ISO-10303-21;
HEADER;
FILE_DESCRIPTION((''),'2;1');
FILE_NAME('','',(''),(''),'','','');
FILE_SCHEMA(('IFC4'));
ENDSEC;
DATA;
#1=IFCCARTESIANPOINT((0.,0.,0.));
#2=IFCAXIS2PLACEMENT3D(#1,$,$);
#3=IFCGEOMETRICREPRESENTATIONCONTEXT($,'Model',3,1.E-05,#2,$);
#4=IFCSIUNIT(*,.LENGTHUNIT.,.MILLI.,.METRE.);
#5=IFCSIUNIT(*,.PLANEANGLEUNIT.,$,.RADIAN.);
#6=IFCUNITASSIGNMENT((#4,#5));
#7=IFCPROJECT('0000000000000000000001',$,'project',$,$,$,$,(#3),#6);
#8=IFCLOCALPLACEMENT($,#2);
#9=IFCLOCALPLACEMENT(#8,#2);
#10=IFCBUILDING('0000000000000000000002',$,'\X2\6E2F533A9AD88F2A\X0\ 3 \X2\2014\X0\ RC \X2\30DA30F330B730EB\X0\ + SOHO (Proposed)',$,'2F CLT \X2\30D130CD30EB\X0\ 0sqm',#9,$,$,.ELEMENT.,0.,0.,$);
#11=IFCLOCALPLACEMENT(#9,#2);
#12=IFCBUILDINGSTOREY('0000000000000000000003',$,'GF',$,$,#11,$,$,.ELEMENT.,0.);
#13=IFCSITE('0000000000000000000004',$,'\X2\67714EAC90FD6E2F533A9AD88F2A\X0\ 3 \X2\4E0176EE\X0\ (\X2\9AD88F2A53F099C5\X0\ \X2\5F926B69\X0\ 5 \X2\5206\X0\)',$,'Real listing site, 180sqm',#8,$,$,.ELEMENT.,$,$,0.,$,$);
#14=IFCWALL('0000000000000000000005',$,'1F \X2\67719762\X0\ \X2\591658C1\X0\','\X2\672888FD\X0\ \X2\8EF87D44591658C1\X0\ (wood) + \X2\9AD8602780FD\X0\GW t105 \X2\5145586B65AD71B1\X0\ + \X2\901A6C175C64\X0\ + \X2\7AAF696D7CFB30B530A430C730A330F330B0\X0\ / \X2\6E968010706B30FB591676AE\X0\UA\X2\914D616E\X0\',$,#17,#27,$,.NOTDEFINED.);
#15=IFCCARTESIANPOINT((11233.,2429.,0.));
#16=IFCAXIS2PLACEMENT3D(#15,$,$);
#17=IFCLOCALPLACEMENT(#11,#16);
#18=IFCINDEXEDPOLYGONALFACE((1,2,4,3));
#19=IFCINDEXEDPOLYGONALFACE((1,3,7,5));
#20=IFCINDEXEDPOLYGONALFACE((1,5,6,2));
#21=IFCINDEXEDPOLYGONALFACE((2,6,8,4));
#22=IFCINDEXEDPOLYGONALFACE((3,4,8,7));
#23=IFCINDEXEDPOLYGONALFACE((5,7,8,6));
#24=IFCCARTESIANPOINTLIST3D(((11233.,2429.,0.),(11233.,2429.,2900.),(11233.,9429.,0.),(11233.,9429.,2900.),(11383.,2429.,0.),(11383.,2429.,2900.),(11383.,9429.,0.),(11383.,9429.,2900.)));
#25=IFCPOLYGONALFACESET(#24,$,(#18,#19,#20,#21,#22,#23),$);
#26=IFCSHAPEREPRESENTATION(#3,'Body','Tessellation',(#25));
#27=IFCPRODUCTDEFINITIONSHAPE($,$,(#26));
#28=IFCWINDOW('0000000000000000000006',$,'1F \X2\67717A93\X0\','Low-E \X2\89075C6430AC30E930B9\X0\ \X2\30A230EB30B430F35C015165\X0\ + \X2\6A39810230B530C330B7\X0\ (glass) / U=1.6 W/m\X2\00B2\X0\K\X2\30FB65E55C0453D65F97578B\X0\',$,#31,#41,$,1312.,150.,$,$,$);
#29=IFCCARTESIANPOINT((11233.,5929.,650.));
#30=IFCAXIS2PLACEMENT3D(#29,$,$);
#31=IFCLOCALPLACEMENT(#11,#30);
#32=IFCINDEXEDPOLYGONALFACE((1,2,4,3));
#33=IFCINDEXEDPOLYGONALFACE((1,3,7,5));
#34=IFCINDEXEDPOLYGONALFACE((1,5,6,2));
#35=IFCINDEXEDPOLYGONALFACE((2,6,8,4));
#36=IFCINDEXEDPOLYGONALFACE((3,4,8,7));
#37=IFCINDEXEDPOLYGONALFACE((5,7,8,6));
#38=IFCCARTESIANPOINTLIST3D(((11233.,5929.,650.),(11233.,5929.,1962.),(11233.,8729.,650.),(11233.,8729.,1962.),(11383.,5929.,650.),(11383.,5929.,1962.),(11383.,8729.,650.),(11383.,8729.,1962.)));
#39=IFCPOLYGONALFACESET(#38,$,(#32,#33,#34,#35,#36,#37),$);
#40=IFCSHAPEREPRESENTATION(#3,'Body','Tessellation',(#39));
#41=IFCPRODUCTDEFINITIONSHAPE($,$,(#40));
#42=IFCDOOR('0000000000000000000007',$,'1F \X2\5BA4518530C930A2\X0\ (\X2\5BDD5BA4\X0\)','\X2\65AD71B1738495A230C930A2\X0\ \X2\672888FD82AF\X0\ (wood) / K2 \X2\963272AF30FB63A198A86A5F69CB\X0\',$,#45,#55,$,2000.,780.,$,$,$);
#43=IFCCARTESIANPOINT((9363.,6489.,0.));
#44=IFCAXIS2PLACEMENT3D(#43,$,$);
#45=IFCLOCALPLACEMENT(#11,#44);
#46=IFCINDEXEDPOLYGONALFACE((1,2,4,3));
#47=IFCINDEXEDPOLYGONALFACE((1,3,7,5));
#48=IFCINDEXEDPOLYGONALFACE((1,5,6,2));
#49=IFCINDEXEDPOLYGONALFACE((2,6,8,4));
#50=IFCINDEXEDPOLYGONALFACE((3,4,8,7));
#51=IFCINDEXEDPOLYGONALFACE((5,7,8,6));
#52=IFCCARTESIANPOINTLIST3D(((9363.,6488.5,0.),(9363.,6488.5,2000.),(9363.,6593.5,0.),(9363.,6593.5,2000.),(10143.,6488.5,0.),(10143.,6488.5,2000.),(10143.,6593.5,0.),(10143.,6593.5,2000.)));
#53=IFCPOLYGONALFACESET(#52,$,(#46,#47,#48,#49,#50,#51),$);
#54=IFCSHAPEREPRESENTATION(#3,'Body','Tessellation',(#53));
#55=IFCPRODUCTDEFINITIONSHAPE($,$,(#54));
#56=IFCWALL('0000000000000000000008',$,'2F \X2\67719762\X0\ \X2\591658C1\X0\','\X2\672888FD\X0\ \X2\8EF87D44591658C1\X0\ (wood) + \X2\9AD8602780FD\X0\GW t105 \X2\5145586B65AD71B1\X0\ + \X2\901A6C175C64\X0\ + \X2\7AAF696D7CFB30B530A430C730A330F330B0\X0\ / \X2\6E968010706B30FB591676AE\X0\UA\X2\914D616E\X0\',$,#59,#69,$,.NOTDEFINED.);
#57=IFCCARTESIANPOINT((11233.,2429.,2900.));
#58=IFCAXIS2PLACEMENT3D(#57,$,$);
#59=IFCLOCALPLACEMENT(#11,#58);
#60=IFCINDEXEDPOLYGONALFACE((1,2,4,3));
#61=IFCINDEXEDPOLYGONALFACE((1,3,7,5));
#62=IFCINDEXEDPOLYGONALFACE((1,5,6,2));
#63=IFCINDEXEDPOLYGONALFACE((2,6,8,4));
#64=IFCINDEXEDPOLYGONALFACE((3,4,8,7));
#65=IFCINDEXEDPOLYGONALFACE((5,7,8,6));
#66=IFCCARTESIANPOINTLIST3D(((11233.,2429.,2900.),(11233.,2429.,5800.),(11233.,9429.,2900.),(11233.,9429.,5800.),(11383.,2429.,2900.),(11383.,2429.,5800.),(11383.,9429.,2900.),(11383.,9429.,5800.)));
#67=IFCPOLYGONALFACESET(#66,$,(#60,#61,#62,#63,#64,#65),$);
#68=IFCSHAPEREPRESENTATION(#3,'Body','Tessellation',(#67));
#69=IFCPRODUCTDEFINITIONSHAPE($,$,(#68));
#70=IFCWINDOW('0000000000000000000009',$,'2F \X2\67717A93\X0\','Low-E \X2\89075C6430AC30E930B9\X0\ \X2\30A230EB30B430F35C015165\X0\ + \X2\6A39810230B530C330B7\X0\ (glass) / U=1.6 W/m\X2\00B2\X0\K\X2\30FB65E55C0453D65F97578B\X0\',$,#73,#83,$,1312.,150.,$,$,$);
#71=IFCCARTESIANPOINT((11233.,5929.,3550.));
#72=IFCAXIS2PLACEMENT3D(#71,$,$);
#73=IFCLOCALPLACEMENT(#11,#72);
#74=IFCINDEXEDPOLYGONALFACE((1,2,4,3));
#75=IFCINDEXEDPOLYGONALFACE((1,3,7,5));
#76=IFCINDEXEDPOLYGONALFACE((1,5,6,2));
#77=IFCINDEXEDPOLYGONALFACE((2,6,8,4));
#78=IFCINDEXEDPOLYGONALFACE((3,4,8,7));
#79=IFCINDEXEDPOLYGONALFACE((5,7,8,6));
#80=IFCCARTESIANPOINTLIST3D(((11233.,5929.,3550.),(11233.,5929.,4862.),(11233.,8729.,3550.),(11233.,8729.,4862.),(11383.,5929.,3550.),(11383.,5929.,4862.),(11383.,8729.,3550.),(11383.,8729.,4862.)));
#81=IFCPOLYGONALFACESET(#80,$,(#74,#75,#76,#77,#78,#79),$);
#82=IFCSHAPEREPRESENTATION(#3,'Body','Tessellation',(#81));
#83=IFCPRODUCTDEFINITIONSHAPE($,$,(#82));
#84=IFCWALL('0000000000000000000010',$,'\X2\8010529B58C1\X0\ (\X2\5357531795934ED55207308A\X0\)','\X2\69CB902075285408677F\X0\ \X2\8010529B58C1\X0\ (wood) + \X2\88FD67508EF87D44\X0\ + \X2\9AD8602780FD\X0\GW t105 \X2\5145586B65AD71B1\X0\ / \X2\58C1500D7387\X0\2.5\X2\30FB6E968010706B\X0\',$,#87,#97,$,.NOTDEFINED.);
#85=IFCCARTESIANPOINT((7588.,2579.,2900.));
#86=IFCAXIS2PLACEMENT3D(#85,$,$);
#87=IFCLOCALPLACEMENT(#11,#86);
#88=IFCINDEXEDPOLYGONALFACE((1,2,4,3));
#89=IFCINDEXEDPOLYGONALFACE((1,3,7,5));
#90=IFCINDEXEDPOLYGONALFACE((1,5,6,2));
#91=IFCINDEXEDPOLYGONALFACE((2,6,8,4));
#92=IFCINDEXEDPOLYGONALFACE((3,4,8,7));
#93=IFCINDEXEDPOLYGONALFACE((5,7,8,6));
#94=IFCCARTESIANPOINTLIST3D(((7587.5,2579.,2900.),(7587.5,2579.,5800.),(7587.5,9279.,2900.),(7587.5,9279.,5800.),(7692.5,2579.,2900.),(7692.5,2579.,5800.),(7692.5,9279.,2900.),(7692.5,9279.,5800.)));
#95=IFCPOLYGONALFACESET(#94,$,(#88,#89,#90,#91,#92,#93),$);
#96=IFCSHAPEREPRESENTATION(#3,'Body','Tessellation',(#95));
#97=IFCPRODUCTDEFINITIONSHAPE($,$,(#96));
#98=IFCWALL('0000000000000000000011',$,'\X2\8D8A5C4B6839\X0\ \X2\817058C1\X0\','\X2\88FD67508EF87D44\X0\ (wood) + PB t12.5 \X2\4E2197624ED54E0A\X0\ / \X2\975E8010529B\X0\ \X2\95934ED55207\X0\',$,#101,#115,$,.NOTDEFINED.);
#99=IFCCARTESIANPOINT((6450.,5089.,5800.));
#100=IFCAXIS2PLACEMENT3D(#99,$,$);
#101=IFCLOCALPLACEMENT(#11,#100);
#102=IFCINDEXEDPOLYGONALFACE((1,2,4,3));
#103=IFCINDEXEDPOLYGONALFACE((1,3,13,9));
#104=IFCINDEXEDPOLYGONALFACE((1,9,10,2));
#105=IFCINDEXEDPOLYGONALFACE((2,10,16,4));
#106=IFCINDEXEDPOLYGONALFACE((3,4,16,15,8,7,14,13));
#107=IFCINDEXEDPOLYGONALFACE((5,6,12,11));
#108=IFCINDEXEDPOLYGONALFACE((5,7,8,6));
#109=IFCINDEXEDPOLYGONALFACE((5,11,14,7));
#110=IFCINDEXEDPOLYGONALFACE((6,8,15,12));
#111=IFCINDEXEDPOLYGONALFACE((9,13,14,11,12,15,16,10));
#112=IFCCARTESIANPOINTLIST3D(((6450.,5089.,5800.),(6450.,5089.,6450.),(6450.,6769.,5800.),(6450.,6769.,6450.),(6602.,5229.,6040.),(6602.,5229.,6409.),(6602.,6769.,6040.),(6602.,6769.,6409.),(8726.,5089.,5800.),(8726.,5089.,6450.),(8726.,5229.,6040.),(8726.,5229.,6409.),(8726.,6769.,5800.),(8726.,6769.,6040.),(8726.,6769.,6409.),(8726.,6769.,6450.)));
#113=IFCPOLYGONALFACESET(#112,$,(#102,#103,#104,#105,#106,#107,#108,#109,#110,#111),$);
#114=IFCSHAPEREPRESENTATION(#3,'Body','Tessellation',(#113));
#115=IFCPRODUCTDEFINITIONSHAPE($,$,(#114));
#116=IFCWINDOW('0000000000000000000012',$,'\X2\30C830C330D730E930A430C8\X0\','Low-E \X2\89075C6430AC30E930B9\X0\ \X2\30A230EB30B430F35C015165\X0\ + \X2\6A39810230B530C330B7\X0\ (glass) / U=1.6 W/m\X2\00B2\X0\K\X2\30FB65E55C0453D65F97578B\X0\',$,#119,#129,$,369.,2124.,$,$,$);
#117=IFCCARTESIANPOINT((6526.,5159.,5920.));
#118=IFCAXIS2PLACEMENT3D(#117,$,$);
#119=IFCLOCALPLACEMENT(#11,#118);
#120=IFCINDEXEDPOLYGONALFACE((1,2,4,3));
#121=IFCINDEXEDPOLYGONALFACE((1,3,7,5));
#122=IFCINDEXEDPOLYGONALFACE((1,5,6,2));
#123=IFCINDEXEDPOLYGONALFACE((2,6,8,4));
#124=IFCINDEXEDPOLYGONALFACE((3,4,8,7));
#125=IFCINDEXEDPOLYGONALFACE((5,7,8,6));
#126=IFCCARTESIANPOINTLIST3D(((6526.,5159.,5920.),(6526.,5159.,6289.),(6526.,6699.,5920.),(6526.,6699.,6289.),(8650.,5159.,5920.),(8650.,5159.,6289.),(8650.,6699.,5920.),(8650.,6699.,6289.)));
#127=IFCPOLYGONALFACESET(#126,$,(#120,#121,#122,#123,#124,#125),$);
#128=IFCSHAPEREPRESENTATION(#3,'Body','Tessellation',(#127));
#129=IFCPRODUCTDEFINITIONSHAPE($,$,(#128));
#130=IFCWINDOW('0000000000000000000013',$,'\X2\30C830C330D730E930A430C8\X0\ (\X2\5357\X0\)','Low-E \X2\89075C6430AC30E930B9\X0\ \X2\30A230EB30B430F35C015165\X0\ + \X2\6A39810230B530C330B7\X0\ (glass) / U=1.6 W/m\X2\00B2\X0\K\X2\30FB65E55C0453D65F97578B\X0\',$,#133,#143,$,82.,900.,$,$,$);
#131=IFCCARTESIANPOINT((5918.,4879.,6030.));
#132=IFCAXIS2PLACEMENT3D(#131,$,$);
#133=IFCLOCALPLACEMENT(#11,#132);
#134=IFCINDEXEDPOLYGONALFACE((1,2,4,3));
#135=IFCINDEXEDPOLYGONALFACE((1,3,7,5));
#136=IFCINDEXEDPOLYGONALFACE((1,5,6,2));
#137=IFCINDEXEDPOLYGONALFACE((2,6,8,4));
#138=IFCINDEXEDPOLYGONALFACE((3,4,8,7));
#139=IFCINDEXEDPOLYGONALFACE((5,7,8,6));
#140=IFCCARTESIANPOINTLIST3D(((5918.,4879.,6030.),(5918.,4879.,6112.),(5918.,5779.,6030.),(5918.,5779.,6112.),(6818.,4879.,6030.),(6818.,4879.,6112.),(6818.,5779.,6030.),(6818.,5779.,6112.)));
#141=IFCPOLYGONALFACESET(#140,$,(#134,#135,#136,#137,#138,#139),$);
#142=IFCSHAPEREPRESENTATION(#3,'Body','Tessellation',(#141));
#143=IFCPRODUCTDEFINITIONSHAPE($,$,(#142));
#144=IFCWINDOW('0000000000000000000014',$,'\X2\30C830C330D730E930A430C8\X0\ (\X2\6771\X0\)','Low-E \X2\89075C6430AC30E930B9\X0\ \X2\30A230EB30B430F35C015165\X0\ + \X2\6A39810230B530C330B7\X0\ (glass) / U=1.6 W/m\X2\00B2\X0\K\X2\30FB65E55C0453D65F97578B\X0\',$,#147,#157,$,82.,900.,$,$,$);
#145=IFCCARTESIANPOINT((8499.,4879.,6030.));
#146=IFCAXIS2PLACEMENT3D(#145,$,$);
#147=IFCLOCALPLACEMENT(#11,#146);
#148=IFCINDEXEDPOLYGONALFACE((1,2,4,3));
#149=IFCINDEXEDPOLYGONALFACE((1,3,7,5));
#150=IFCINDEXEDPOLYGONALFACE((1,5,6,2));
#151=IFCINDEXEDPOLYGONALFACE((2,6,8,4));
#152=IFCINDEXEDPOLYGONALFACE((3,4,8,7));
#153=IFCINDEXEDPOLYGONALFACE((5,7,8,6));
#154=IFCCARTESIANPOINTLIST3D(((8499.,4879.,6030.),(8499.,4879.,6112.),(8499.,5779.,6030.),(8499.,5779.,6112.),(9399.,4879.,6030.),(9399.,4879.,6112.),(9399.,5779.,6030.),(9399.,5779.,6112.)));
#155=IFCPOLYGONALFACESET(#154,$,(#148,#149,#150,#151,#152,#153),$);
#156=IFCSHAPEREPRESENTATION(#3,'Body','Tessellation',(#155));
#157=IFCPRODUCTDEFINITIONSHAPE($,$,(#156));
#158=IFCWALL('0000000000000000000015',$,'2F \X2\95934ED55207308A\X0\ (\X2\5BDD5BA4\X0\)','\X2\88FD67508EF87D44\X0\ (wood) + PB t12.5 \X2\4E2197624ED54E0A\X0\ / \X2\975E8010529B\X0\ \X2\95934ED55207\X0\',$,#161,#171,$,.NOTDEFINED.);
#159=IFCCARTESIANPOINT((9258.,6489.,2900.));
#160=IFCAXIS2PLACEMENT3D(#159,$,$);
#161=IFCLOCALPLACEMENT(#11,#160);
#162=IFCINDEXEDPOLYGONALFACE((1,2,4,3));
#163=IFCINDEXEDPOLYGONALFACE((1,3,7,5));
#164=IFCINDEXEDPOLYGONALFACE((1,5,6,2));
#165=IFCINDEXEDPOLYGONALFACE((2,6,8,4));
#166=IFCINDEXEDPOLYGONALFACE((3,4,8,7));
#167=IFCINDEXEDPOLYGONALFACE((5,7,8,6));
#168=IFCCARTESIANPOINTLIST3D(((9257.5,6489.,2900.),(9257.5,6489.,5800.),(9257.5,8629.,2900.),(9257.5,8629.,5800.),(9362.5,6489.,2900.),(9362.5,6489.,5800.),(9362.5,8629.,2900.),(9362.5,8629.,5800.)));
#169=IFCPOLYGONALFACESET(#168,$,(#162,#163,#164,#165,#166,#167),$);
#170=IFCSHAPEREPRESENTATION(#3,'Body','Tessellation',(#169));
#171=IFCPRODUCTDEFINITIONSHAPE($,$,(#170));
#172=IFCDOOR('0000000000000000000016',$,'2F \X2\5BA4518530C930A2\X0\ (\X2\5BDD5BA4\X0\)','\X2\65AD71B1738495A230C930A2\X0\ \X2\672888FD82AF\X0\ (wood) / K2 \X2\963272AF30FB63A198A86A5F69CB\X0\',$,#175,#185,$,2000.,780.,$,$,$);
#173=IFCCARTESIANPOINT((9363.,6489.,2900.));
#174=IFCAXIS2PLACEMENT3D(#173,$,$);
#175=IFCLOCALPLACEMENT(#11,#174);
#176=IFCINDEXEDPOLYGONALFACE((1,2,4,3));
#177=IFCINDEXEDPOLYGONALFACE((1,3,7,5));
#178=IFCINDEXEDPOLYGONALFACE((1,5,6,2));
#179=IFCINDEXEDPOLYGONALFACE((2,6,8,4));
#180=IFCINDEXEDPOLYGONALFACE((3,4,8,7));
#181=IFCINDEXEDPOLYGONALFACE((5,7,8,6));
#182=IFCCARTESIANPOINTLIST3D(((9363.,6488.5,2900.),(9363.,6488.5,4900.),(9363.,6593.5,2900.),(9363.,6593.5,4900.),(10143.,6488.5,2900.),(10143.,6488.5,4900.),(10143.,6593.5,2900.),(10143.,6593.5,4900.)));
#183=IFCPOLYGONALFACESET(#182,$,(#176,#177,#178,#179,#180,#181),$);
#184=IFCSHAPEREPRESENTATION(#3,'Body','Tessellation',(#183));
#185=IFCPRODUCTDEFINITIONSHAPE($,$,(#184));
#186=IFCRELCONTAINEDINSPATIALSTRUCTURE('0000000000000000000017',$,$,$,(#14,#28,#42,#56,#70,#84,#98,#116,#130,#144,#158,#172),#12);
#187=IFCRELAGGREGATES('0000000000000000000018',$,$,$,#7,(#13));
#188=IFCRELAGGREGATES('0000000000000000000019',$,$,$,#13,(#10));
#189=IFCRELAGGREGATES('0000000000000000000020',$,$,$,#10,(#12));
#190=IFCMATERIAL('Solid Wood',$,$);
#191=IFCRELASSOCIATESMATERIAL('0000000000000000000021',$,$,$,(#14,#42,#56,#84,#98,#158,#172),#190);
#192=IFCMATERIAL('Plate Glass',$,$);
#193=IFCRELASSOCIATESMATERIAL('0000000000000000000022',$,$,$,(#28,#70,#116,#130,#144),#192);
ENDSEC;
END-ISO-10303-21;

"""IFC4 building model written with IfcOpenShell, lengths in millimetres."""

from ifc_helpers import new_model, si_unit, frame, frame_2d, origin, place, context, project, spatial, rectangle, extrude, material, element, fill, save


model = new_model("IFC4")

# Units and contexts
model_context = context("Model", 3, precision=1e-05, world=origin())
ifc_project = project(units=[si_unit("LENGTHUNIT", "METRE", prefix="MILLI"), si_unit("PLANEANGLEUNIT", "RADIAN")], contexts=[model_context])

# Site, building, storey
site_placement = place(None, origin())
site = spatial("IfcSite", under=ifc_project, at=site_placement, Name="東京都港区高輪 3 丁目 (高輪台駅 徒歩 5 分)", ObjectType="Real listing site, 180sqm", CompositionType="ELEMENT", RefElevation=0.0)
building_placement = place(site_placement, origin())
building = spatial("IfcBuilding", under=site, at=building_placement, Name="港区高輪 3 — RC ペンシル + SOHO (Proposed)", ObjectType="2F CLT パネル 0sqm", CompositionType="ELEMENT", ElevationOfRefHeight=0.0, ElevationOfTerrain=0.0)
storey_placement = place(building_placement, origin())
storey = spatial("IfcBuildingStorey", under=building, at=storey_placement, Name="GF", CompositionType="ELEMENT", Elevation=0.0)

# Wall, opening, window
ifc_material_1 = material(Name="Solid Wood")
wall_1_placement = place(storey_placement, frame((11233.0, 2429.0, 0.0)))
wall_1 = element("IfcWall", 1, at=wall_1_placement, inside=storey, material=ifc_material_1, Name="1F 東面 外壁", Description="木製 軸組外壁 (wood) + 高性能GW t105 充填断熱 + 通気層 + 窯業系サイディング / 準耐火・外皮UA配慮", PredefinedType="NOTDEFINED", context=model_context, shape_type="SweptSolid", body=[
    extrude(rectangle(XDim=150.0, YDim=7000.0, at=frame_2d((75.0, 3500.0))), frame((11233.0, 2429.0, 0.0)), (0.0, 0.0, 1.0), 2900.0),
])
opening_1_placement = place(storey_placement, frame((11233.0, 5929.0, 650.0)))
opening_1 = element("IfcOpeningElement", 2, at=opening_1_placement, cuts=wall_1, PredefinedType="NOTDEFINED", context=model_context, shape_type="SweptSolid", body=[
    extrude(rectangle(XDim=150.0, YDim=2800.0, at=frame_2d((75.0, 1400.0))), frame((11233.0, 5929.0, 650.0)), (0.0, 0.0, 1.0), 1312.0),
])
ifc_material_2 = material(Name="Plate Glass")
window_1_placement = place(storey_placement, frame((11233.0, 5929.0, 650.0)))
window_1 = element("IfcWindow", 3, at=window_1_placement, inside=storey, material=ifc_material_2, Name="1F 東窓", Description="Low-E 複層ガラス アルゴン封入 + 樹脂サッシ (glass) / U=1.6 W/m²K・日射取得型", OverallHeight=1312.0, OverallWidth=150.0, context=model_context, shape_type="SweptSolid", body=[
    extrude(rectangle(XDim=150.0, YDim=2800.0, at=frame_2d((75.0, 1400.0))), frame((11233.0, 5929.0, 650.0)), (0.0, 0.0, 1.0), 1312.0),
])
fill(opening_1, window_1)

# Door
door_1_placement = place(storey_placement, frame((9363.0, 6489.0, 0.0)))
element("IfcDoor", 4, at=door_1_placement, inside=storey, material=ifc_material_1, Name="1F 室内ドア (寝室)", Description="断熱玄関ドア 木製芯 (wood) / K2 防犯・採風機構", OverallHeight=2000.0, OverallWidth=780.0, context=model_context, shape_type="SweptSolid", body=[
    extrude(rectangle(XDim=780.0, YDim=105.0, at=frame_2d((390.0, 52.0))), frame((9363.0, 6489.0, 0.0)), (0.0, 0.0, 1.0), 2000.0),
])

# Wall, opening, window
wall_2_placement = place(storey_placement, frame((11233.0, 2429.0, 2900.0)))
wall_2 = element("IfcWall", 5, at=wall_2_placement, inside=storey, material=ifc_material_1, Name="2F 東面 外壁", Description="木製 軸組外壁 (wood) + 高性能GW t105 充填断熱 + 通気層 + 窯業系サイディング / 準耐火・外皮UA配慮", PredefinedType="NOTDEFINED", context=model_context, shape_type="SweptSolid", body=[
    extrude(rectangle(XDim=150.0, YDim=7000.0, at=frame_2d((75.0, 3500.0))), frame((11233.0, 2429.0, 2900.0)), (0.0, 0.0, 1.0), 2900.0),
])
opening_2_placement = place(storey_placement, frame((11233.0, 5929.0, 3550.0)))
opening_2 = element("IfcOpeningElement", 6, at=opening_2_placement, cuts=wall_2, PredefinedType="NOTDEFINED", context=model_context, shape_type="SweptSolid", body=[
    extrude(rectangle(XDim=150.0, YDim=2800.0, at=frame_2d((75.0, 1400.0))), frame((11233.0, 5929.0, 3550.0)), (0.0, 0.0, 1.0), 1312.0),
])
window_2_placement = place(storey_placement, frame((11233.0, 5929.0, 3550.0)))
window_2 = element("IfcWindow", 7, at=window_2_placement, inside=storey, material=ifc_material_2, Name="2F 東窓", Description="Low-E 複層ガラス アルゴン封入 + 樹脂サッシ (glass) / U=1.6 W/m²K・日射取得型", OverallHeight=1312.0, OverallWidth=150.0, context=model_context, shape_type="SweptSolid", body=[
    extrude(rectangle(XDim=150.0, YDim=2800.0, at=frame_2d((75.0, 1400.0))), frame((11233.0, 5929.0, 3550.0)), (0.0, 0.0, 1.0), 1312.0),
])
fill(opening_2, window_2)

# Wall
wall_3_placement = place(storey_placement, frame((7588.0, 2579.0, 2900.0)))
element("IfcWall", 8, at=wall_3_placement, inside=storey, material=ifc_material_1, Name="耐力壁 (南北間仕切り)", Description="構造用合板 耐力壁 (wood) + 製材軸組 + 高性能GW t105 充填断熱 / 壁倍率2.5・準耐火", PredefinedType="NOTDEFINED", context=model_context, shape_type="SweptSolid", body=[
    extrude(rectangle(XDim=105.0, YDim=6700.0, at=frame_2d((52.0, 3350.0))), frame((7588.0, 2579.0, 2900.0)), (0.0, 0.0, 1.0), 2900.0),
])

# Wall, openings, windows
wall_4_placement = place(storey_placement, frame((6450.0, 5089.0, 5800.0)))
wall_4 = element("IfcWall", 9, at=wall_4_placement, inside=storey, material=ifc_material_1, Name="越屋根 腰壁", Description="製材軸組 (wood) + PB t12.5 両面仕上 / 非耐力 間仕切", PredefinedType="NOTDEFINED", context=model_context, shape_type="SweptSolid", body=[
    extrude(rectangle(XDim=2276.0, YDim=1680.0, at=frame_2d((1138.0, 840.0))), frame((6450.0, 5089.0, 5800.0)), (0.0, 0.0, 1.0), 650.0),
])
opening_3_placement = place(storey_placement, frame((6526.0, 5159.0, 5920.0)))
opening_3 = element("IfcOpeningElement", 10, at=opening_3_placement, cuts=wall_4, PredefinedType="NOTDEFINED", context=model_context, shape_type="SweptSolid", body=[
    extrude(rectangle(XDim=2124.0, YDim=1540.0, at=frame_2d((1062.0, 770.0))), frame((6526.0, 5159.0, 5920.0)), (0.0, 0.0, 1.0), 369.0),
])
opening_4_placement = place(storey_placement, frame((5918.0, 4879.0, 6030.0)))
opening_4 = element("IfcOpeningElement", 11, at=opening_4_placement, cuts=wall_4, PredefinedType="NOTDEFINED", context=model_context, shape_type="SweptSolid", body=[
    extrude(rectangle(XDim=900.0, YDim=900.0, at=frame_2d((450.0, 450.0))), frame((5918.0, 4879.0, 6030.0)), (0.0, 0.0, 1.0), 82.0),
])
opening_5_placement = place(storey_placement, frame((8499.0, 4879.0, 6030.0)))
opening_5 = element("IfcOpeningElement", 12, at=opening_5_placement, cuts=wall_4, PredefinedType="NOTDEFINED", context=model_context, shape_type="SweptSolid", body=[
    extrude(rectangle(XDim=900.0, YDim=900.0, at=frame_2d((450.0, 450.0))), frame((8499.0, 4879.0, 6030.0)), (0.0, 0.0, 1.0), 82.0),
])
window_3_placement = place(storey_placement, frame((6526.0, 5159.0, 5920.0)))
window_3 = element("IfcWindow", 13, at=window_3_placement, inside=storey, material=ifc_material_2, Name="トップライト", Description="Low-E 複層ガラス アルゴン封入 + 樹脂サッシ (glass) / U=1.6 W/m²K・日射取得型", OverallHeight=369.0, OverallWidth=2124.0, context=model_context, shape_type="SweptSolid", body=[
    extrude(rectangle(XDim=2124.0, YDim=1540.0, at=frame_2d((1062.0, 770.0))), frame((6526.0, 5159.0, 5920.0)), (0.0, 0.0, 1.0), 369.0),
])
fill(opening_3, window_3)
window_4_placement = place(storey_placement, frame((5918.0, 4879.0, 6030.0)))
window_4 = element("IfcWindow", 14, at=window_4_placement, inside=storey, material=ifc_material_2, Name="トップライト (南)", Description="Low-E 複層ガラス アルゴン封入 + 樹脂サッシ (glass) / U=1.6 W/m²K・日射取得型", OverallHeight=82.0, OverallWidth=900.0, context=model_context, shape_type="SweptSolid", body=[
    extrude(rectangle(XDim=900.0, YDim=900.0, at=frame_2d((450.0, 450.0))), frame((5918.0, 4879.0, 6030.0)), (0.0, 0.0, 1.0), 82.0),
])
fill(opening_4, window_4)
window_5_placement = place(storey_placement, frame((8499.0, 4879.0, 6030.0)))
window_5 = element("IfcWindow", 15, at=window_5_placement, inside=storey, material=ifc_material_2, Name="トップライト (東)", Description="Low-E 複層ガラス アルゴン封入 + 樹脂サッシ (glass) / U=1.6 W/m²K・日射取得型", OverallHeight=82.0, OverallWidth=900.0, context=model_context, shape_type="SweptSolid", body=[
    extrude(rectangle(XDim=900.0, YDim=900.0, at=frame_2d((450.0, 450.0))), frame((8499.0, 4879.0, 6030.0)), (0.0, 0.0, 1.0), 82.0),
])
fill(opening_5, window_5)

# Wall
wall_5_placement = place(storey_placement, frame((9258.0, 6489.0, 2900.0)))
element("IfcWall", 16, at=wall_5_placement, inside=storey, material=ifc_material_1, Name="2F 間仕切り (寝室)", Description="製材軸組 (wood) + PB t12.5 両面仕上 / 非耐力 間仕切", PredefinedType="NOTDEFINED", context=model_context, shape_type="SweptSolid", body=[
    extrude(rectangle(XDim=105.0, YDim=2140.0, at=frame_2d((52.0, 1070.0))), frame((9258.0, 6489.0, 2900.0)), (0.0, 0.0, 1.0), 2900.0),
])

# Door
door_2_placement = place(storey_placement, frame((9363.0, 6489.0, 2900.0)))
element("IfcDoor", 17, at=door_2_placement, inside=storey, material=ifc_material_1, Name="2F 室内ドア (寝室)", Description="断熱玄関ドア 木製芯 (wood) / K2 防犯・採風機構", OverallHeight=2000.0, OverallWidth=780.0, context=model_context, shape_type="SweptSolid", body=[
    extrude(rectangle(XDim=780.0, YDim=105.0, at=frame_2d((390.0, 52.0))), frame((9363.0, 6489.0, 2900.0)), (0.0, 0.0, 1.0), 2000.0),
])

save(model, "model.ifc")
